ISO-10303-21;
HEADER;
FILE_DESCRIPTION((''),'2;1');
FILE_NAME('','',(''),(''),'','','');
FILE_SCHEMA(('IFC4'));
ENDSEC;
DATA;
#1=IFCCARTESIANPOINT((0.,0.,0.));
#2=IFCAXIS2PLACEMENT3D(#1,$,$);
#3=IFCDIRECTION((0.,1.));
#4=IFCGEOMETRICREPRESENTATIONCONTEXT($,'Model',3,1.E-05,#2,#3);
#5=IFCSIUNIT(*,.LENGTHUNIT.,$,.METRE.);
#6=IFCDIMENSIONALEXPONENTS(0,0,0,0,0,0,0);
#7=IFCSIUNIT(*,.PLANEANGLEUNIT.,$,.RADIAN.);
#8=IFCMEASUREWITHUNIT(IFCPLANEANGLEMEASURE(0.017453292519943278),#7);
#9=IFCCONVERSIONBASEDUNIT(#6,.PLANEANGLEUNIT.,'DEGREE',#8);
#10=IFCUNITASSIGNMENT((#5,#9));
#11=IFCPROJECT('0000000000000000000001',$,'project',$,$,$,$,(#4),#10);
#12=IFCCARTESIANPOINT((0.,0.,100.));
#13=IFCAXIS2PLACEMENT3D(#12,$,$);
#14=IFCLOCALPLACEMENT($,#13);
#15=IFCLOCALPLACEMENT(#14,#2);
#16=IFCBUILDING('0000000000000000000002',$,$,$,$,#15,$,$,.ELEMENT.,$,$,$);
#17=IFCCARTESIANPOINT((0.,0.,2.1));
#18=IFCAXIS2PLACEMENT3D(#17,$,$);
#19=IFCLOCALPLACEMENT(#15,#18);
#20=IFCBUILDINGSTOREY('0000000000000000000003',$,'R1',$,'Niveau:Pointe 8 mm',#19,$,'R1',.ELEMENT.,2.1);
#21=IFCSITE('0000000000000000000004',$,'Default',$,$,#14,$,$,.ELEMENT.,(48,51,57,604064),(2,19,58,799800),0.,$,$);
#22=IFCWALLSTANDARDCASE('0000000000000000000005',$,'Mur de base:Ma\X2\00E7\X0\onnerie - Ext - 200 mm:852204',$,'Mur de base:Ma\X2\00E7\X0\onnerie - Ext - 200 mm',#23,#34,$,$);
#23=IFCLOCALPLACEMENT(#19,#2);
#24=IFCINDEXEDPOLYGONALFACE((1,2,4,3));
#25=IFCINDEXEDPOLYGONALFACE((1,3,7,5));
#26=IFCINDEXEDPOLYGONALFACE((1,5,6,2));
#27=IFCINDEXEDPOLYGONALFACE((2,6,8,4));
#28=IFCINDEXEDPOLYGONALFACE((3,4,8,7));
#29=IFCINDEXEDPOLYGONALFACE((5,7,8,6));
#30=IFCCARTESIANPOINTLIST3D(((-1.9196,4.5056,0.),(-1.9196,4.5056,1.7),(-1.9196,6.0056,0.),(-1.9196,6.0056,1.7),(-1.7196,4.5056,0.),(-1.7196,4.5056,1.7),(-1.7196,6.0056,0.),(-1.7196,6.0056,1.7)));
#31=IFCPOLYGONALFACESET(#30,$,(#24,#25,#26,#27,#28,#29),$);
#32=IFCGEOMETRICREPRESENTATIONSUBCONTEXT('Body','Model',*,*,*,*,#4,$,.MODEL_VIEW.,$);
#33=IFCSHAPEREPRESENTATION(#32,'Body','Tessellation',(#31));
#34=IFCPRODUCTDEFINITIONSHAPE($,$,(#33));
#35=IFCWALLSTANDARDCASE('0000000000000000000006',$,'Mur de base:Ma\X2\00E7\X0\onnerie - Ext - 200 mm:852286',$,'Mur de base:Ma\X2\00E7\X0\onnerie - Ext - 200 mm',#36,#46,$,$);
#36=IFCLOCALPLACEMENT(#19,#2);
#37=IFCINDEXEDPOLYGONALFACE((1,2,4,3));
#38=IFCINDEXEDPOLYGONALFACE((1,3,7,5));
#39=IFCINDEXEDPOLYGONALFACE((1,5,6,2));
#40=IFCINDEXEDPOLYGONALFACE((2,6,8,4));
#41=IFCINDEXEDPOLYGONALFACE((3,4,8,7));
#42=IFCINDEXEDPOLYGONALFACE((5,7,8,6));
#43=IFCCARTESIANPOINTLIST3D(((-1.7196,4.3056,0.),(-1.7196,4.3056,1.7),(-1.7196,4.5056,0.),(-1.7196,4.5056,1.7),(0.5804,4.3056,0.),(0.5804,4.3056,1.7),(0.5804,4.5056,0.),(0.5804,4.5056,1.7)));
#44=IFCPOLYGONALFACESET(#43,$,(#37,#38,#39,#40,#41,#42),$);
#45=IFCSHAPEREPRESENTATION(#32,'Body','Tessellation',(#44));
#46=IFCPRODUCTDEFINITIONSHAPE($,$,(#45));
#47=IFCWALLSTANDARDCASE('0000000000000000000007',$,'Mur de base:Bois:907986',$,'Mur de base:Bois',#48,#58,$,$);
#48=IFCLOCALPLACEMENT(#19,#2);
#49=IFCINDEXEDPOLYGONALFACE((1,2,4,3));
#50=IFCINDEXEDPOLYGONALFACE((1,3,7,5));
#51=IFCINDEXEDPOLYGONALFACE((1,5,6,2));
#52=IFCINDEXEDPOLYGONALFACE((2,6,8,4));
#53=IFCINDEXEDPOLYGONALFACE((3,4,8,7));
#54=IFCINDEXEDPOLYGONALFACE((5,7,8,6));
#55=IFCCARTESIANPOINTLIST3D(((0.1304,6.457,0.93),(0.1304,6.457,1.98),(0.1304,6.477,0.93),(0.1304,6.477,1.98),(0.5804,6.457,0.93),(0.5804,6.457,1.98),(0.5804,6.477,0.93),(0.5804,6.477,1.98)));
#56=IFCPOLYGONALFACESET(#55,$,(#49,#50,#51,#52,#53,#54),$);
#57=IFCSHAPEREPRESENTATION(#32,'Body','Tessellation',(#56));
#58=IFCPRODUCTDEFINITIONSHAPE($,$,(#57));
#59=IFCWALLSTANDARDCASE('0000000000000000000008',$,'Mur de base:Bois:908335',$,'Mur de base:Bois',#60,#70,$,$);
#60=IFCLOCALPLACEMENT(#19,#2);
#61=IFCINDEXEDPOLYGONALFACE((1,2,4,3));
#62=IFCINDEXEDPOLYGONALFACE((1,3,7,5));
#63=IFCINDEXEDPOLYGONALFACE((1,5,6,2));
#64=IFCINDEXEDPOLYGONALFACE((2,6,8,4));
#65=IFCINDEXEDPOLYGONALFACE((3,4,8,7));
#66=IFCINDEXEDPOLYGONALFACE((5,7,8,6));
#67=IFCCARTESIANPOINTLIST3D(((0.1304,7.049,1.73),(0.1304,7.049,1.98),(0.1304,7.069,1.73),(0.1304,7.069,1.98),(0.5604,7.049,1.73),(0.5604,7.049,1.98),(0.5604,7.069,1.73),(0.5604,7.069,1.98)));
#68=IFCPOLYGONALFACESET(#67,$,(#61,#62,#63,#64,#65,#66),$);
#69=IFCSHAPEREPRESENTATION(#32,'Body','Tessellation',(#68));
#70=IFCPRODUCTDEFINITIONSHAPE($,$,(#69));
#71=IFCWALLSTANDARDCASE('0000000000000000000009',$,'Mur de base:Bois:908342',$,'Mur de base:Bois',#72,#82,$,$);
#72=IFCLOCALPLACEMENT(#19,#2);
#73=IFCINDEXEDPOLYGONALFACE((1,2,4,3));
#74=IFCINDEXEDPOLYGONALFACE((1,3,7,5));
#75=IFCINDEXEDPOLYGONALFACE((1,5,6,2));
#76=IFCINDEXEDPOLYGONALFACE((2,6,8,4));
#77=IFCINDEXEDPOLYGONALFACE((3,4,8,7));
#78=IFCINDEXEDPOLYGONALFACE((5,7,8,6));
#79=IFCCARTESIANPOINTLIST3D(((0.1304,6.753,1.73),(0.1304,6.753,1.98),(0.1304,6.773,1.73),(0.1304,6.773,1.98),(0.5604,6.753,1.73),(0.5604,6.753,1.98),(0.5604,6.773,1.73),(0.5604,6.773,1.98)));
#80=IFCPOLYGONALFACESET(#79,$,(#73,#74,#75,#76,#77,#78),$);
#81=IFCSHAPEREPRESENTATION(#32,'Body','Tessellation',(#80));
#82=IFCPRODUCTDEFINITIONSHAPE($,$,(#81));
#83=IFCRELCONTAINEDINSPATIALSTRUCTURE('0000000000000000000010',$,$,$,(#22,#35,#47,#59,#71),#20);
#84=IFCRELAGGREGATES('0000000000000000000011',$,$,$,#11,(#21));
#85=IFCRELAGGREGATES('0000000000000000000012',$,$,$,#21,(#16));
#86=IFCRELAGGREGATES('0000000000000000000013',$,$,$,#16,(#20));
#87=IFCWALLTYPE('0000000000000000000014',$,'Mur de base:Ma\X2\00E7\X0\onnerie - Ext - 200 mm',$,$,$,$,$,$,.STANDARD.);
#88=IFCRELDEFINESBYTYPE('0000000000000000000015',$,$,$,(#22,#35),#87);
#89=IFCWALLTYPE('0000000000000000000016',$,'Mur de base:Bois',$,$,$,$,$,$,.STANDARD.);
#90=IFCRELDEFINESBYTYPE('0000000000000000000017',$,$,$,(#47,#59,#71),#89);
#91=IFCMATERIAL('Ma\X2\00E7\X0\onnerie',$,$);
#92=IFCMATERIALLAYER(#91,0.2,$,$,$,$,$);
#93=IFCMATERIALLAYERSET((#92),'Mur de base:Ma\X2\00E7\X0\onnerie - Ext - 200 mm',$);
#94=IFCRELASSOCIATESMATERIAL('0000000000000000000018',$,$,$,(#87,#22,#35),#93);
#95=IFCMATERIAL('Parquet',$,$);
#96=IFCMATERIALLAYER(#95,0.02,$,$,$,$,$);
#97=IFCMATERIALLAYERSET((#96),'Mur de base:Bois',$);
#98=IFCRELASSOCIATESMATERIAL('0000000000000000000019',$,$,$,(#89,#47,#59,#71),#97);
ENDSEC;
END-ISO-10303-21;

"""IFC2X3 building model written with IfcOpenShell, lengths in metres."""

from ifc_helpers import new_model, entity, si_unit, converted_unit, direction, frame, frame_2d, origin, place, context, subcontext, project, spatial, polyline, rectangle, extrude, clip, bounded_halfspace, material, layer, layer_set, layer_usage, type_object, element, save


model = new_model("IFC2X3")

# Units and contexts
model_context = context("Model", 3, precision=1e-05, world=origin(), true_north=direction((0.0, 1.0)))
body_context = subcontext(model_context, "Body", "Model", "MODEL_VIEW")
ifc_project = project(units=[si_unit("LENGTHUNIT", "METRE"), converted_unit("PLANEANGLEUNIT", "DEGREE", entity("IfcPlaneAngleMeasure", 0.017453292519943278), si_unit("PLANEANGLEUNIT", "RADIAN"), dimensions=[0, 0, 0, 0, 0, 0, 0])], contexts=[model_context])

# Site, building, storey
site_placement = place(None, frame((0.0, 0.0, 100.0)))
site = spatial("IfcSite", under=ifc_project, at=site_placement, Name="Default", CompositionType="ELEMENT", RefLatitude=(48, 51, 57, 604064), RefLongitude=(2, 19, 58, 799800), RefElevation=0.0)
building_placement = place(site_placement, origin())
building = spatial("IfcBuilding", under=site, at=building_placement, CompositionType="ELEMENT")
storey_placement = place(building_placement, frame((0.0, 0.0, 2.1)))
storey = spatial("IfcBuildingStorey", under=building, at=storey_placement, Name="R1", ObjectType="Niveau:Pointe 8 mm", LongName="R1", CompositionType="ELEMENT", Elevation=2.1)

# Walls
ifc_material_1 = material(Name="Maçonnerie")
ifc_layer_1 = layer(ifc_material_1, 0.2)
ifc_layer_set_1 = layer_set([ifc_layer_1], Name="Mur de base:Maçonnerie - Ext - 200 mm")
wall_type_1 = type_object("IfcWallType", Name="Mur de base:Maçonnerie - Ext - 200 mm", PredefinedType="STANDARD", material=ifc_layer_set_1)
ifc_layer_usage_1 = layer_usage(ifc_layer_set_1, "AXIS2", "NEGATIVE", 0.1)
wall_1_placement = place(storey_placement, frame((-1.8196, 4.5056, 0.0), z_axis=(0.0, 0.0, 1.0), x_axis=(0.0, 1.0, 0.0)))
element("IfcWallStandardCase", 1, at=wall_1_placement, inside=storey, type_object=wall_type_1, material=ifc_layer_usage_1, Name="Mur de base:Maçonnerie - Ext - 200 mm:852204", ObjectType="Mur de base:Maçonnerie - Ext - 200 mm", context=body_context, shape_type="SweptSolid", body=[
    extrude(rectangle(XDim=1.5, YDim=0.2, at=frame_2d((0.75, 0.0), x_axis=(-1.0, 0.0))), origin(), (0.0, 0.0, 1.0), 1.7),
])
ifc_layer_usage_2 = layer_usage(ifc_layer_set_1, "AXIS2", "NEGATIVE", 0.1)
wall_2_placement = place(storey_placement, frame((-1.7196, 4.4056, 0.0)))
element("IfcWallStandardCase", 2, at=wall_2_placement, inside=storey, type_object=wall_type_1, material=ifc_layer_usage_2, Name="Mur de base:Maçonnerie - Ext - 200 mm:852286", ObjectType="Mur de base:Maçonnerie - Ext - 200 mm", context=body_context, shape_type="Clipping", body=[
    clip(clip(extrude(rectangle(XDim=2.3, YDim=0.2, at=frame_2d((1.15, 0.0), x_axis=(-1.0, 0.0))), origin(), (0.0, 0.0, 1.0), 1.7), bounded_halfspace(frame((2.3, -0.1, 1.7), z_axis=(-1.0, 0.0, 0.0), x_axis=(0.0, 0.0, -1.0)), True, frame((2.3, -0.1, 1.7), z_axis=(-1.0, 0.0, 0.0), x_axis=(0.0, 0.0, -1.0)), polyline([(0.0, 0.0), (0.0, -0.2), (1.7, -0.2), (1.7, 0.0), (0.0, 0.0)]))), bounded_halfspace(frame((0.0, -0.1, 0.0), z_axis=(1.0, 0.0, 0.0), x_axis=(0.0, 0.0, -1.0)), True, frame((0.0, -0.1, 0.0), z_axis=(1.0, 0.0, 0.0), x_axis=(0.0, 0.0, -1.0)), polyline([(0.0, 0.0), (0.0, 0.2), (-1.7, 0.2), (-1.7, 0.0), (0.0, 0.0)]))),
])
ifc_material_2 = material(Name="Parquet")
ifc_layer_2 = layer(ifc_material_2, 0.02)
ifc_layer_set_2 = layer_set([ifc_layer_2], Name="Mur de base:Bois")
ifc_layer_usage_3 = layer_usage(ifc_layer_set_2, "AXIS2", "NEGATIVE", 0.01)
wall_type_2 = type_object("IfcWallType", Name="Mur de base:Bois", PredefinedType="STANDARD", material=ifc_layer_set_2)
wall_3_placement = place(storey_placement, frame((0.5804, 6.467, 0.93), z_axis=(0.0, 0.0, 1.0), x_axis=(-1.0, 0.0, 0.0)))
element("IfcWallStandardCase", 3, at=wall_3_placement, inside=storey, type_object=wall_type_2, material=ifc_layer_usage_3, Name="Mur de base:Bois:907986", ObjectType="Mur de base:Bois", context=body_context, shape_type="SweptSolid", body=[
    extrude(rectangle(XDim=0.45, YDim=0.02, at=frame_2d((0.225, 0.0), x_axis=(-1.0, 0.0))), origin(), (0.0, 0.0, 1.0), 1.05),
])
ifc_layer_usage_4 = layer_usage(ifc_layer_set_2, "AXIS2", "NEGATIVE", 0.01)
wall_4_placement = place(storey_placement, frame((0.5604, 7.059, 1.73), z_axis=(0.0, 0.0, 1.0), x_axis=(-1.0, 0.0, 0.0)))
element("IfcWallStandardCase", 4, at=wall_4_placement, inside=storey, type_object=wall_type_2, material=ifc_layer_usage_4, Name="Mur de base:Bois:908335", ObjectType="Mur de base:Bois", context=body_context, shape_type="SweptSolid", body=[
    extrude(rectangle(XDim=0.43, YDim=0.02, at=frame_2d((0.215, 0.0), x_axis=(-1.0, 0.0))), origin(), (0.0, 0.0, 1.0), 0.25),
])
ifc_layer_usage_5 = layer_usage(ifc_layer_set_2, "AXIS2", "NEGATIVE", 0.01)
wall_5_placement = place(storey_placement, frame((0.5604, 6.763, 1.73), z_axis=(0.0, 0.0, 1.0), x_axis=(-1.0, 0.0, 0.0)))
element("IfcWallStandardCase", 5, at=wall_5_placement, inside=storey, type_object=wall_type_2, material=ifc_layer_usage_5, Name="Mur de base:Bois:908342", ObjectType="Mur de base:Bois", context=body_context, shape_type="SweptSolid", body=[
    extrude(rectangle(XDim=0.43, YDim=0.02, at=frame_2d((0.215, 0.0), x_axis=(-1.0, 0.0))), origin(), (0.0, 0.0, 1.0), 0.25),
])

save(model, "model.ifc")
